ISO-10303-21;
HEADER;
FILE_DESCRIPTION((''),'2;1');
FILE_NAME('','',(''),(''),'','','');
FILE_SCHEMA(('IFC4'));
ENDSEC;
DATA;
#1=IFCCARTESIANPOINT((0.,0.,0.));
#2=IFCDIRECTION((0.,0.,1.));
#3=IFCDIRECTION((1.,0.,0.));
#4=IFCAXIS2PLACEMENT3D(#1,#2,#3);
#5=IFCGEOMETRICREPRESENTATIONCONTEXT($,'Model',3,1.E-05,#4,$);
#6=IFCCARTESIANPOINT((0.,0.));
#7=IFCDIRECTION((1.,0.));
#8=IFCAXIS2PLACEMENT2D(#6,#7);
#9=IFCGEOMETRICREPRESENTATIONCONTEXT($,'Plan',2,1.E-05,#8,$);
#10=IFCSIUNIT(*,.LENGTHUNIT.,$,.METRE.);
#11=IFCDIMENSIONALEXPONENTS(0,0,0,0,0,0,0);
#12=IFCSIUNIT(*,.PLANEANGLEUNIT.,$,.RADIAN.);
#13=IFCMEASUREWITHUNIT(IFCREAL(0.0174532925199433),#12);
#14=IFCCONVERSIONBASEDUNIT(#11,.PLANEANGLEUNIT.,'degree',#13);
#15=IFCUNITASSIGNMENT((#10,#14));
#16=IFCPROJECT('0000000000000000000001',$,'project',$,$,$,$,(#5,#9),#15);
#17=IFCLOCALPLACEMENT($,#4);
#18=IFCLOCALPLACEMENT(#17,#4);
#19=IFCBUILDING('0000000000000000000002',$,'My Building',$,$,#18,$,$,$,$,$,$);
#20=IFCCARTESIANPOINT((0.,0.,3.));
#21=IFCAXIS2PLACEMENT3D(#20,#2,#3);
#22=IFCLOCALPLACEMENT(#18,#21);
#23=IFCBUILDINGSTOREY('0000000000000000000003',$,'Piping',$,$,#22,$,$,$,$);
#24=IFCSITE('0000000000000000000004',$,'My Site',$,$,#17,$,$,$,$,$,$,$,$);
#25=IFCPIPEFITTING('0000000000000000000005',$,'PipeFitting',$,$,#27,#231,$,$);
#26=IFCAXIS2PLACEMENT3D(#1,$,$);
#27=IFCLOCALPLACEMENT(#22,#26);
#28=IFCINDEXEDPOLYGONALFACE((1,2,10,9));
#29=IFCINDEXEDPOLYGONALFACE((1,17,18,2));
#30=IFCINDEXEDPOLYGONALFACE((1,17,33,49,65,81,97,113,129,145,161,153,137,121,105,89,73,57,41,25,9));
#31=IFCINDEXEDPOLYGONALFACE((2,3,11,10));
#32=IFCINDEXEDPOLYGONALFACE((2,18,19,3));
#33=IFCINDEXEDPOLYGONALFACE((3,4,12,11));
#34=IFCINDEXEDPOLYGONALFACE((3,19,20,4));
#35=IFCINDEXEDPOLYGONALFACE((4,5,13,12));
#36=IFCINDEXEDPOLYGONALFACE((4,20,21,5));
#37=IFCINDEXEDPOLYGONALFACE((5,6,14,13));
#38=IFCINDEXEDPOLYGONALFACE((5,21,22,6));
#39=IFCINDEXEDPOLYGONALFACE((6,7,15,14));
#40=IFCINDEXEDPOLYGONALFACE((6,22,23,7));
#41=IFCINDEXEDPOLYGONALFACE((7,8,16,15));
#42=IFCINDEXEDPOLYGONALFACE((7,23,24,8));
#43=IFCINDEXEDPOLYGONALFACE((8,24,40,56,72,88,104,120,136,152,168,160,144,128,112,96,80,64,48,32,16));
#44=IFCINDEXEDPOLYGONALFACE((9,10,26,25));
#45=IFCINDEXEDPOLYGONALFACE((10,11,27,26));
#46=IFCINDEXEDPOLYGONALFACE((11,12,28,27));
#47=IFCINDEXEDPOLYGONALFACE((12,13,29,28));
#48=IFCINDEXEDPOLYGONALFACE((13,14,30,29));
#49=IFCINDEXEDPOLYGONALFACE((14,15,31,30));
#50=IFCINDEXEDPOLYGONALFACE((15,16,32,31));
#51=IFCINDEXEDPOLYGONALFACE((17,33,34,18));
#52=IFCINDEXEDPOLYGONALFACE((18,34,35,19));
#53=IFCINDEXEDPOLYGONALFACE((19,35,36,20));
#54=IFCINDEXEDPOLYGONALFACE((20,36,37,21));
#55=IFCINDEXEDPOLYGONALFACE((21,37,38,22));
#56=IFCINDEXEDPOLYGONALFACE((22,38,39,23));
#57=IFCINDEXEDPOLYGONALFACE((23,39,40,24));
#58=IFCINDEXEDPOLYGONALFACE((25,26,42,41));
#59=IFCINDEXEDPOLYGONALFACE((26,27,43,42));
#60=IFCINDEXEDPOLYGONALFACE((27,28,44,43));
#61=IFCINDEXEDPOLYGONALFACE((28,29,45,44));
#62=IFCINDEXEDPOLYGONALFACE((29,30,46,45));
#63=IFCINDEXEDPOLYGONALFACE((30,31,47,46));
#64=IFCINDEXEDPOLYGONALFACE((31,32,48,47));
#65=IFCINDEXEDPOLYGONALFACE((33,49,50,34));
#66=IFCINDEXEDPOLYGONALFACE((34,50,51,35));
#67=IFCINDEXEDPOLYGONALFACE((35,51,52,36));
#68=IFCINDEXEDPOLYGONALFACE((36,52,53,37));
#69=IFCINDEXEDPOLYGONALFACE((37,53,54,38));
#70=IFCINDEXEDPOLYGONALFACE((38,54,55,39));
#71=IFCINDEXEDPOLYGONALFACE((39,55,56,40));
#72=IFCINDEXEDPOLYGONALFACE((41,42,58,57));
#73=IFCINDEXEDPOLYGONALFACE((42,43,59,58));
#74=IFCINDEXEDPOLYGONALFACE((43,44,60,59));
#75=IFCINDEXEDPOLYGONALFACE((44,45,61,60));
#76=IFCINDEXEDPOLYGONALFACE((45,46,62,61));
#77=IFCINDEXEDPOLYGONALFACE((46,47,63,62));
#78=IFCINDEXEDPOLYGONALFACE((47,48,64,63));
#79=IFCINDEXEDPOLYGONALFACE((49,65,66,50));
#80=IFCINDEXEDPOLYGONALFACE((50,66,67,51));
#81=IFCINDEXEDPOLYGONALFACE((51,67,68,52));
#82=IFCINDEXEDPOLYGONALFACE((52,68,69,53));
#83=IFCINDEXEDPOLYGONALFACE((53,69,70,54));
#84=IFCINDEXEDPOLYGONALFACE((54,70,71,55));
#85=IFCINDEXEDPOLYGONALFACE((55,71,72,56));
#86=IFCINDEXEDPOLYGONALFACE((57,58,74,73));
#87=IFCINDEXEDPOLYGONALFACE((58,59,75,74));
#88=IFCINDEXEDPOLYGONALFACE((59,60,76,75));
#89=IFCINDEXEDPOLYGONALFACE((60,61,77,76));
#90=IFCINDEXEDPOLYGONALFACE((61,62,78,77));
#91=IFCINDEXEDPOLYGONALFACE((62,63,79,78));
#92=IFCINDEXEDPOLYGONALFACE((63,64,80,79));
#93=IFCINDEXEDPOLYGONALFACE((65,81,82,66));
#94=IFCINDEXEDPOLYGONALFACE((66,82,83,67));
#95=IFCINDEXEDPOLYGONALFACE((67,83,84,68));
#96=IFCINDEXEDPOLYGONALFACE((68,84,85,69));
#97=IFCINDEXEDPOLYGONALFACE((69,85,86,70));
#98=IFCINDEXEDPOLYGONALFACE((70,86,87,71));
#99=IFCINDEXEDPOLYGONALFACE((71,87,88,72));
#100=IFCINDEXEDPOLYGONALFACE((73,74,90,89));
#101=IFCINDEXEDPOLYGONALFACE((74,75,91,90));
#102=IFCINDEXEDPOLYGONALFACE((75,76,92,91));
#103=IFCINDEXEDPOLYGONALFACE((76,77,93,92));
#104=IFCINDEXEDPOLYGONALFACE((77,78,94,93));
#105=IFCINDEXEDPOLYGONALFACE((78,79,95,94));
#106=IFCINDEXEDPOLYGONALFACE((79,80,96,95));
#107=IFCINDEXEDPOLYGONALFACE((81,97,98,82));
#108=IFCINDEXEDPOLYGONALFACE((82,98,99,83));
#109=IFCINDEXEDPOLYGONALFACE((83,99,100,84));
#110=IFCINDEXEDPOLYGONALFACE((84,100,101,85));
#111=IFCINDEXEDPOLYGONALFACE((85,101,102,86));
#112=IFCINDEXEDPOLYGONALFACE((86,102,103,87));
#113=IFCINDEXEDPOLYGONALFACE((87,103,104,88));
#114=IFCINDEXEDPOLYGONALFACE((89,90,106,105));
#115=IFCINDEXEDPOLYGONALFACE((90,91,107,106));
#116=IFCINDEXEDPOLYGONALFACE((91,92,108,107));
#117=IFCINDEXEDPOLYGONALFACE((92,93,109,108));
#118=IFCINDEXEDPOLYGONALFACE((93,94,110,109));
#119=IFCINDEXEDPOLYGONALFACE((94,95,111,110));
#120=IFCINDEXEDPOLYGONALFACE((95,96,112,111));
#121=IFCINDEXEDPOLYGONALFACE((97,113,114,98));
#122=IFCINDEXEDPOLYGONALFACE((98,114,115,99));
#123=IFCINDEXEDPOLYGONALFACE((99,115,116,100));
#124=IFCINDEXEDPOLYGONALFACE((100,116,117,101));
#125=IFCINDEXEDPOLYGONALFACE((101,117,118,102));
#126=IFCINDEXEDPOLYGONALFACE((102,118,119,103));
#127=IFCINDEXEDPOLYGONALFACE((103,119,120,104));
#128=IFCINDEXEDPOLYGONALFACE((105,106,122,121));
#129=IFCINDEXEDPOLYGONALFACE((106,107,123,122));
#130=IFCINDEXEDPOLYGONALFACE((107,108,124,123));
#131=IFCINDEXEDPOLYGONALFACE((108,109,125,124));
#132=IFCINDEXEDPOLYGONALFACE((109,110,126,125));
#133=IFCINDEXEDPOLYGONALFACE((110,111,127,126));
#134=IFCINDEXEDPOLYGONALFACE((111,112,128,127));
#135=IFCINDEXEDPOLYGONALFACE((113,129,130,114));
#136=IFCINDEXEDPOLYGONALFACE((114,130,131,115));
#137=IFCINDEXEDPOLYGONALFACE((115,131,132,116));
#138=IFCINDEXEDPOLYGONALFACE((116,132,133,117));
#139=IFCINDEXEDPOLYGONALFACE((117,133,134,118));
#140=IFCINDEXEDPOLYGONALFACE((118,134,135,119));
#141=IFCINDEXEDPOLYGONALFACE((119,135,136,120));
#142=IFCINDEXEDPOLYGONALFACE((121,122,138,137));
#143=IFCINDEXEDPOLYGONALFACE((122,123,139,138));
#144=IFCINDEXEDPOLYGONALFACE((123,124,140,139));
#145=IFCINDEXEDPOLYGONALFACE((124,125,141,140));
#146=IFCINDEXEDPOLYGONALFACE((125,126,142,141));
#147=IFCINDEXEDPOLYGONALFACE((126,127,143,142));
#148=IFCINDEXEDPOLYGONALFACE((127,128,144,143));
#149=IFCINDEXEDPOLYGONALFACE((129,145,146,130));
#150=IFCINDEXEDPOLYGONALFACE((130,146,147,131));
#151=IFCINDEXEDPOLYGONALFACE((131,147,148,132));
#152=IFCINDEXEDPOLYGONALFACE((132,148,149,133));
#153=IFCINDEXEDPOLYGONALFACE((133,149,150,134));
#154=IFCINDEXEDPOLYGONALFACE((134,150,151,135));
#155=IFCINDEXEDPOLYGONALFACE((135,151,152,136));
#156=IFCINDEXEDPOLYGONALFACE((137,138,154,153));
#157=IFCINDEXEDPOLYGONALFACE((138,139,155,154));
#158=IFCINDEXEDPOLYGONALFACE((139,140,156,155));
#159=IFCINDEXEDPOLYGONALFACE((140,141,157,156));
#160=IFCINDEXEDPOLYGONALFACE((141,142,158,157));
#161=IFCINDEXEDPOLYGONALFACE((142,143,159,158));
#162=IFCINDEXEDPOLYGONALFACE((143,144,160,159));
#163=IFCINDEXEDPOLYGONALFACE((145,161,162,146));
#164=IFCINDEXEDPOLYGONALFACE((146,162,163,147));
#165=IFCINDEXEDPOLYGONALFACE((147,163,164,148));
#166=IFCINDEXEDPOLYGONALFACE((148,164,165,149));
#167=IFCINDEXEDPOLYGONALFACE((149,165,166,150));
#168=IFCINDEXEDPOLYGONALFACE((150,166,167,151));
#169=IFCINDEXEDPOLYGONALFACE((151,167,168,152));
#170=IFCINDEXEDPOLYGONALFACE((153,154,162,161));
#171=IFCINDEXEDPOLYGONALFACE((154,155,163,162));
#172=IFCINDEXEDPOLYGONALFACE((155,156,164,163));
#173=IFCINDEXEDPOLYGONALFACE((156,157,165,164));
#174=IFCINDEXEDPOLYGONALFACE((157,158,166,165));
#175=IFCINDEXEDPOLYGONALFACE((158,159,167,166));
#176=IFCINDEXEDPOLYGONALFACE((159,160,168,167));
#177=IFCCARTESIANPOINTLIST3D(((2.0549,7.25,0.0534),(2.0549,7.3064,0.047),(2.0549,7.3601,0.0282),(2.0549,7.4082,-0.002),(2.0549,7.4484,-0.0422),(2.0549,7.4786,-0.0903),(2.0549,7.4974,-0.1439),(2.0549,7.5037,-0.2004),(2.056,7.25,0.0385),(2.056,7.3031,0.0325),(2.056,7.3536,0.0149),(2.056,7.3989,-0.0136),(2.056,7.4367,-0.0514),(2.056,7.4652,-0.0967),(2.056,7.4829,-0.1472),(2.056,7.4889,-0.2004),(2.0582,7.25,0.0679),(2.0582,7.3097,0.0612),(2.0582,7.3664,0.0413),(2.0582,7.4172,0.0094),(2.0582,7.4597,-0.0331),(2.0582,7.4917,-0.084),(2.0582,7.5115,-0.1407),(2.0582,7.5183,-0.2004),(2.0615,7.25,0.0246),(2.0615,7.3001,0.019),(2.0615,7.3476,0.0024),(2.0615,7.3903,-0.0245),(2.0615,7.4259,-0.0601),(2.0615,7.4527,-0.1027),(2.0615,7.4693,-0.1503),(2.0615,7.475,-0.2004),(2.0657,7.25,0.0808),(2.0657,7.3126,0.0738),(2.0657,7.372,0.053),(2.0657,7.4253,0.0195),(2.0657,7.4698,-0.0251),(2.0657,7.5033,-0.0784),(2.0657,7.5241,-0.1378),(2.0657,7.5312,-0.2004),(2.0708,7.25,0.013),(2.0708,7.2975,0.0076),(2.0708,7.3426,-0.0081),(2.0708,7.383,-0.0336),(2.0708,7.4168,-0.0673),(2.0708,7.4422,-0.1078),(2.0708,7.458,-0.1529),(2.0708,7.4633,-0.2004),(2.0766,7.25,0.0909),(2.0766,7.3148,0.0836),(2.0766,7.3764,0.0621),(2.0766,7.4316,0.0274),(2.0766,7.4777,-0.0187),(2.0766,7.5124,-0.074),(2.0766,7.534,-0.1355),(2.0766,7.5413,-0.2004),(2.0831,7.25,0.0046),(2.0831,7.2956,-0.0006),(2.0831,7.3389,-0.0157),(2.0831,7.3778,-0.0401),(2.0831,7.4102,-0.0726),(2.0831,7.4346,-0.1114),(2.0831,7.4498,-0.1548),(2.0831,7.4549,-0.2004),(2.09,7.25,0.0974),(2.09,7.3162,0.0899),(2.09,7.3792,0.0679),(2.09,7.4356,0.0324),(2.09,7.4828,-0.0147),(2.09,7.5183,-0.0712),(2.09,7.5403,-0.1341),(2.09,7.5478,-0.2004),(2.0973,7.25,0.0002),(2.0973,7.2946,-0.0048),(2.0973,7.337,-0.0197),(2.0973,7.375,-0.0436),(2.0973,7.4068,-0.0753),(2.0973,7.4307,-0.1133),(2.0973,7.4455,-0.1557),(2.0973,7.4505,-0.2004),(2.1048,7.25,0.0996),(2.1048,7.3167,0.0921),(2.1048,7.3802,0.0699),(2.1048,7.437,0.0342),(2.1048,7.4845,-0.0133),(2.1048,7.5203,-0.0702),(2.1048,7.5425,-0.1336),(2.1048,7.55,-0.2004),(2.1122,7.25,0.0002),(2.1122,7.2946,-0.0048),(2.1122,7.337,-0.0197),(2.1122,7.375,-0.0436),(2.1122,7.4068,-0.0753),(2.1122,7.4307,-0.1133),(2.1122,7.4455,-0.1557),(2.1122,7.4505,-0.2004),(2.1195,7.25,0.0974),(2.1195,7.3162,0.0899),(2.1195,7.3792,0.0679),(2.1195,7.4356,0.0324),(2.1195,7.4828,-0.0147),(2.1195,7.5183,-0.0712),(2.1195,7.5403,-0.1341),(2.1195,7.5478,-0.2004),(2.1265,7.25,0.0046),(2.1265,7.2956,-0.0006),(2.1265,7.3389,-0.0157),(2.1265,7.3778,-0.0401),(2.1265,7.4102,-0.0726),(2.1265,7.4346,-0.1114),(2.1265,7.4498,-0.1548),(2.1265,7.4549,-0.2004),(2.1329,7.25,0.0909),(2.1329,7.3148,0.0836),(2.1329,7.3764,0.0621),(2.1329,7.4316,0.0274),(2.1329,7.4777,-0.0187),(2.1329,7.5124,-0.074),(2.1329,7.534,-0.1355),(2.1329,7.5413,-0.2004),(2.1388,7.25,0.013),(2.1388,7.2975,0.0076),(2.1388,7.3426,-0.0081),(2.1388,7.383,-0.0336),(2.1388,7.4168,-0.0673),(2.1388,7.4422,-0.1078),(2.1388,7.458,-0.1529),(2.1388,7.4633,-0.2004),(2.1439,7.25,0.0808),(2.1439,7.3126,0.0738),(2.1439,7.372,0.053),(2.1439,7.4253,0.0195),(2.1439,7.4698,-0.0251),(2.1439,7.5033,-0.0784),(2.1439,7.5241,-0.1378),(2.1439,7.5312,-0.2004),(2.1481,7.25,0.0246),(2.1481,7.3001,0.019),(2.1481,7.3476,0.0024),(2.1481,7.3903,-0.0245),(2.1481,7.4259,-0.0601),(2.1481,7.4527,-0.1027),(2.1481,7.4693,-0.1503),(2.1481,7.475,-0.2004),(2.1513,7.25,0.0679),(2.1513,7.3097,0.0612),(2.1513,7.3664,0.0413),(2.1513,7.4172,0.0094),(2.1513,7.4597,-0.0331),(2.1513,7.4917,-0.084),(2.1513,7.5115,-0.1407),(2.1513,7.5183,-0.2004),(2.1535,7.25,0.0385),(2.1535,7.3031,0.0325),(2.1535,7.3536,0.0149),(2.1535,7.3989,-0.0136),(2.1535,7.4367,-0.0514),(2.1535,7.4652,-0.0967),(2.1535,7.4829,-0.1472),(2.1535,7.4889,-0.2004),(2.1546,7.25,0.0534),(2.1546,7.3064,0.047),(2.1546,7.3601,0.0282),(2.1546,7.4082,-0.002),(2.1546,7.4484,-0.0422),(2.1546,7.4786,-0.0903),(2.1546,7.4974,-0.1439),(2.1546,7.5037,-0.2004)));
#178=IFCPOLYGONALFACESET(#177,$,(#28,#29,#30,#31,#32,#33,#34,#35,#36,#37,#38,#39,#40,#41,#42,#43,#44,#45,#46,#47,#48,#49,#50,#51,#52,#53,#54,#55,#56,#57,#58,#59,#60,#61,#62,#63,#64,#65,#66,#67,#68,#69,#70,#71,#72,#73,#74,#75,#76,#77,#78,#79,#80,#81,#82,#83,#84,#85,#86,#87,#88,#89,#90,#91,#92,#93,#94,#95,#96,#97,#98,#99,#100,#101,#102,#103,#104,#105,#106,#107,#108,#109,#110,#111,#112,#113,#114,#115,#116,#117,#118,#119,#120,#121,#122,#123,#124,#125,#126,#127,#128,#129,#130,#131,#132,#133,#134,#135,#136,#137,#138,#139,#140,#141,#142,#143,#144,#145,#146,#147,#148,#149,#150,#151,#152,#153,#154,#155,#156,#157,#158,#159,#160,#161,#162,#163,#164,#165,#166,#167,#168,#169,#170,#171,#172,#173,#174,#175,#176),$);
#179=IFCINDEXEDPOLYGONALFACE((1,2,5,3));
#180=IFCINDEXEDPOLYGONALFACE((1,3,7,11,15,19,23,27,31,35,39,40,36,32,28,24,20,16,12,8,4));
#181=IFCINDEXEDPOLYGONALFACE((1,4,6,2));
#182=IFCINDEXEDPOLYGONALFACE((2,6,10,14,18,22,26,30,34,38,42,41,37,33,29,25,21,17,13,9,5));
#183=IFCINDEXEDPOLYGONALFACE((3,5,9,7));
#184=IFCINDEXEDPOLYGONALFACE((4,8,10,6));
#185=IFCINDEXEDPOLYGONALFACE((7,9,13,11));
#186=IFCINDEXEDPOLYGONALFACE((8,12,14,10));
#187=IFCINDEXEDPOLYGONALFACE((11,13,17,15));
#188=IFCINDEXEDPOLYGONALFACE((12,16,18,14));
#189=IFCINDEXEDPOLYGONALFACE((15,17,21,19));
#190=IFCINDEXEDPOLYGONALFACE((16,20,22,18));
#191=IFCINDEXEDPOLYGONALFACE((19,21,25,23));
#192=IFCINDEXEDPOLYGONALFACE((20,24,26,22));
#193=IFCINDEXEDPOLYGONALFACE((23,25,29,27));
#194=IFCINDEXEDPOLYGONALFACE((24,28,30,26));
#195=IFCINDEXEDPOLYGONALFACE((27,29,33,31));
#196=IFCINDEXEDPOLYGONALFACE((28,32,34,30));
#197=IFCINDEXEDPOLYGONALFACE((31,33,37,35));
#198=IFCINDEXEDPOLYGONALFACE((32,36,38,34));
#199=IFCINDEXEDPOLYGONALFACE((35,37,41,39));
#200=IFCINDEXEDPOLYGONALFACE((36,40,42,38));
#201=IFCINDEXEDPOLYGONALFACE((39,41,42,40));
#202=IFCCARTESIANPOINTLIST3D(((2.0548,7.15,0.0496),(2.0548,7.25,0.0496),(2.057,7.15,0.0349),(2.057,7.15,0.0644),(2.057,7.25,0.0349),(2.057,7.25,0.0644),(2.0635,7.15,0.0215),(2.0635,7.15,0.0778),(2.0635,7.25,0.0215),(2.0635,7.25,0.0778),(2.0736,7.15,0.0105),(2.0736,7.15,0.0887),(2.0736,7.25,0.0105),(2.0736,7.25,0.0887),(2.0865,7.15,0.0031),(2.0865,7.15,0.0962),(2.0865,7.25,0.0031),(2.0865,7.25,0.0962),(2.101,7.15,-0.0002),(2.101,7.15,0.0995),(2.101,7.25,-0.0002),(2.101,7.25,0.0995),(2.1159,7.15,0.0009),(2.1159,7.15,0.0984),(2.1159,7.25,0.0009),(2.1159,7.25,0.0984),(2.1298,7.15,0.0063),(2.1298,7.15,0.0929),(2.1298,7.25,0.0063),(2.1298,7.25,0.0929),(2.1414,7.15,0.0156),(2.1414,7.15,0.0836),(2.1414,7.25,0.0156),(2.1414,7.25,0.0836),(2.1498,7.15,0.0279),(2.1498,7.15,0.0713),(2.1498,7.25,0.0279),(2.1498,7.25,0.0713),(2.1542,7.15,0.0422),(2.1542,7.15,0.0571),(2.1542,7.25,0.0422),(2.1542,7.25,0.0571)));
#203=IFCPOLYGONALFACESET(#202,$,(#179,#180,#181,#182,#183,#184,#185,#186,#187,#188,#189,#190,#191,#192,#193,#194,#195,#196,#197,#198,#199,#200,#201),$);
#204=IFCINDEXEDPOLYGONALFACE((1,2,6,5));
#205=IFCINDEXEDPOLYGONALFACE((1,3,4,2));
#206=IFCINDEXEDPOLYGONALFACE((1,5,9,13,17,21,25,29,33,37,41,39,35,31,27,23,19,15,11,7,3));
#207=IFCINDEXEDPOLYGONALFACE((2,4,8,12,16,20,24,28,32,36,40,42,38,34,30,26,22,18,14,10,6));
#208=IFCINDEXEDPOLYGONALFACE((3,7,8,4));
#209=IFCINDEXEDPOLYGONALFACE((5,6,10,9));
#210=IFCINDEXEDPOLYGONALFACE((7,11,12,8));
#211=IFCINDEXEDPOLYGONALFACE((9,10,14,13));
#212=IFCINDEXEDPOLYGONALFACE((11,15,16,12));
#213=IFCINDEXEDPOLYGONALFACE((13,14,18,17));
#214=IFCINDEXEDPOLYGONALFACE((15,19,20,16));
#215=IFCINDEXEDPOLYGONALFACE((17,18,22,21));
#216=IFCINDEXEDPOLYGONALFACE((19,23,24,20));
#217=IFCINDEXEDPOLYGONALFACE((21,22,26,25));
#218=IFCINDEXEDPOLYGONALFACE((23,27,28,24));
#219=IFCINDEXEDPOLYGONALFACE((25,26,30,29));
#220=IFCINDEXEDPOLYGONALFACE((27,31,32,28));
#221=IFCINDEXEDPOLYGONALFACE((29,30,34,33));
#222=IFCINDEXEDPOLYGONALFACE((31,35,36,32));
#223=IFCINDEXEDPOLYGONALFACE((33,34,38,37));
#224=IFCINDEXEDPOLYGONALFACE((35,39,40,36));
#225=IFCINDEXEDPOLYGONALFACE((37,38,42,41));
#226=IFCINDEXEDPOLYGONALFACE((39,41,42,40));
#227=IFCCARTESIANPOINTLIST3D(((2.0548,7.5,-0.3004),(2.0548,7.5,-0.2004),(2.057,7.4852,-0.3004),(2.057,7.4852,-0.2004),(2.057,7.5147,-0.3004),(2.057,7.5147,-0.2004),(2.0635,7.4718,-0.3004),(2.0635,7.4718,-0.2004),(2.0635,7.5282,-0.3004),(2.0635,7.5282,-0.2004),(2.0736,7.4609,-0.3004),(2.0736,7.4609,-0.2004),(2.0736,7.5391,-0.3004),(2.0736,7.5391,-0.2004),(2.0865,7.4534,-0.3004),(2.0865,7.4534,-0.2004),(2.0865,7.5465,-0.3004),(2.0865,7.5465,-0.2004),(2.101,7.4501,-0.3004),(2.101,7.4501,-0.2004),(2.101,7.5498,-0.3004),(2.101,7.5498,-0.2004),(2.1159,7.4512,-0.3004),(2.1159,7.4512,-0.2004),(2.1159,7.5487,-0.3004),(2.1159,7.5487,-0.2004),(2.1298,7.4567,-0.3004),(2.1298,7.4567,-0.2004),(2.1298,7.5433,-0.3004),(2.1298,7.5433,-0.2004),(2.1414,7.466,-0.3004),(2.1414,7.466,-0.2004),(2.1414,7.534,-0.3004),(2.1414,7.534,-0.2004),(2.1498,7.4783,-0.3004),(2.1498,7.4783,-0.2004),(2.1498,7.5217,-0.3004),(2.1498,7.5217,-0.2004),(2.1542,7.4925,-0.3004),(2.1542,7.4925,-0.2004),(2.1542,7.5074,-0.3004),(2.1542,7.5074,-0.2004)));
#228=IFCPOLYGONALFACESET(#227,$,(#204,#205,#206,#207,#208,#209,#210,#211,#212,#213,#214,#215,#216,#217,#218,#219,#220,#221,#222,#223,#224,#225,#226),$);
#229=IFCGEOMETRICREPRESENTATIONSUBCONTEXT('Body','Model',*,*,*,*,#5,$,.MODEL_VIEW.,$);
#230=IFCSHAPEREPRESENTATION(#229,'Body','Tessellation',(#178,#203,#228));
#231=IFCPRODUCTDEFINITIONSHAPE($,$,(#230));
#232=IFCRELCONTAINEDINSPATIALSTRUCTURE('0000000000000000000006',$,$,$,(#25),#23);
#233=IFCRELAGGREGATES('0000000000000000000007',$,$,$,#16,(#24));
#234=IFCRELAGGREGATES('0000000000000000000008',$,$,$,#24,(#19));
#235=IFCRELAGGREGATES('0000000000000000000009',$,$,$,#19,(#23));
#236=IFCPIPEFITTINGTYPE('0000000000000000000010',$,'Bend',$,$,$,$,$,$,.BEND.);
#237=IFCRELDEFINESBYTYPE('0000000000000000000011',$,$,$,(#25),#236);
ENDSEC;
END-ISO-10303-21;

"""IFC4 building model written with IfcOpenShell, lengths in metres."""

from ifc_helpers import new_model, entity, si_unit, converted_unit, frame, origin_with_axes, origin_2d_with_axis, place, context, subcontext, project, spatial, circle, extrude, source, transform, mapped, type_object, type_shapes, element, save


model = new_model("IFC4")

# Units and contexts
model_context = context("Model", 3, precision=1e-05, world=origin_with_axes())
plan_context = context("Plan", 2, precision=1e-05, world=origin_2d_with_axis())
body_context = subcontext(model_context, "Body", "Model", "MODEL_VIEW")
ifc_project = project(units=[si_unit("LENGTHUNIT", "METRE"), converted_unit("PLANEANGLEUNIT", "degree", entity("IfcReal", 0.0174532925199433), si_unit("PLANEANGLEUNIT", "RADIAN"), dimensions=[0, 0, 0, 0, 0, 0, 0])], contexts=[model_context, plan_context])

# Site, building, storey
site_placement = place(None, origin_with_axes())
site = spatial("IfcSite", under=ifc_project, at=site_placement, Name="My Site")
building_placement = place(site_placement, origin_with_axes())
building = spatial("IfcBuilding", under=site, at=building_placement, Name="My Building")
storey_placement = place(building_placement, frame((0.0, 0.0, 3.0), z_axis=(0.0, 0.0, 1.0), x_axis=(1.0, 0.0, 0.0)))
storey = spatial("IfcBuildingStorey", under=building, at=storey_placement, Name="Piping")

# Pipe fitting
pipe_fitting_type_1 = type_object("IfcPipeFittingType", Name="Bend", PredefinedType="BEND")
shared_shape = source(origin_with_axes(), body_context, "Body", "SolidModel", [
    entity("IfcSweptDiskSolid", entity("IfcIndexedPolyCurve", entity("IfcCartesianPointList3D", [[0.0, 0.0, 0.1], [0.0, -0.0732, 0.2768], [0.0, -0.25, 0.35]]), [entity("IfcArcIndex", [1, 2, 3])]), 0.05),
    extrude(circle(Radius=0.05), origin_with_axes(), (0.0, 0.0, 1.0), 0.1),
    extrude(circle(Radius=0.05), frame((0.0, -0.25, 0.35), z_axis=(0.0, -1.0, 0.0), x_axis=(1.0, 0.0, 0.0)), (0.0, 0.0, 1.0), 0.1),
])
type_shapes(pipe_fitting_type_1, [shared_shape])
for number, where, z_axis, x_axis, name in (
    (1, (2.1048, 7.15, 0.0496), (0.0, 1.0, 0.0), (-1.0, 0.0, 0.0), "PipeFitting"),
):
    element("IfcPipeFitting", number, at=place(storey_placement, frame(where, z_axis=z_axis, x_axis=x_axis)), inside=storey, type_object=pipe_fitting_type_1, Name=name, context=body_context, shape_type="MappedRepresentation", body=[
        mapped(shared_shape, transform((0.0, 0.0, 0.0), x_axis=(1.0, 0.0, 0.0), y_axis=(0.0, 1.0, 0.0), z_axis=(0.0, 0.0, 1.0), scale=1.0)),
    ])

save(model, "model.ifc")
